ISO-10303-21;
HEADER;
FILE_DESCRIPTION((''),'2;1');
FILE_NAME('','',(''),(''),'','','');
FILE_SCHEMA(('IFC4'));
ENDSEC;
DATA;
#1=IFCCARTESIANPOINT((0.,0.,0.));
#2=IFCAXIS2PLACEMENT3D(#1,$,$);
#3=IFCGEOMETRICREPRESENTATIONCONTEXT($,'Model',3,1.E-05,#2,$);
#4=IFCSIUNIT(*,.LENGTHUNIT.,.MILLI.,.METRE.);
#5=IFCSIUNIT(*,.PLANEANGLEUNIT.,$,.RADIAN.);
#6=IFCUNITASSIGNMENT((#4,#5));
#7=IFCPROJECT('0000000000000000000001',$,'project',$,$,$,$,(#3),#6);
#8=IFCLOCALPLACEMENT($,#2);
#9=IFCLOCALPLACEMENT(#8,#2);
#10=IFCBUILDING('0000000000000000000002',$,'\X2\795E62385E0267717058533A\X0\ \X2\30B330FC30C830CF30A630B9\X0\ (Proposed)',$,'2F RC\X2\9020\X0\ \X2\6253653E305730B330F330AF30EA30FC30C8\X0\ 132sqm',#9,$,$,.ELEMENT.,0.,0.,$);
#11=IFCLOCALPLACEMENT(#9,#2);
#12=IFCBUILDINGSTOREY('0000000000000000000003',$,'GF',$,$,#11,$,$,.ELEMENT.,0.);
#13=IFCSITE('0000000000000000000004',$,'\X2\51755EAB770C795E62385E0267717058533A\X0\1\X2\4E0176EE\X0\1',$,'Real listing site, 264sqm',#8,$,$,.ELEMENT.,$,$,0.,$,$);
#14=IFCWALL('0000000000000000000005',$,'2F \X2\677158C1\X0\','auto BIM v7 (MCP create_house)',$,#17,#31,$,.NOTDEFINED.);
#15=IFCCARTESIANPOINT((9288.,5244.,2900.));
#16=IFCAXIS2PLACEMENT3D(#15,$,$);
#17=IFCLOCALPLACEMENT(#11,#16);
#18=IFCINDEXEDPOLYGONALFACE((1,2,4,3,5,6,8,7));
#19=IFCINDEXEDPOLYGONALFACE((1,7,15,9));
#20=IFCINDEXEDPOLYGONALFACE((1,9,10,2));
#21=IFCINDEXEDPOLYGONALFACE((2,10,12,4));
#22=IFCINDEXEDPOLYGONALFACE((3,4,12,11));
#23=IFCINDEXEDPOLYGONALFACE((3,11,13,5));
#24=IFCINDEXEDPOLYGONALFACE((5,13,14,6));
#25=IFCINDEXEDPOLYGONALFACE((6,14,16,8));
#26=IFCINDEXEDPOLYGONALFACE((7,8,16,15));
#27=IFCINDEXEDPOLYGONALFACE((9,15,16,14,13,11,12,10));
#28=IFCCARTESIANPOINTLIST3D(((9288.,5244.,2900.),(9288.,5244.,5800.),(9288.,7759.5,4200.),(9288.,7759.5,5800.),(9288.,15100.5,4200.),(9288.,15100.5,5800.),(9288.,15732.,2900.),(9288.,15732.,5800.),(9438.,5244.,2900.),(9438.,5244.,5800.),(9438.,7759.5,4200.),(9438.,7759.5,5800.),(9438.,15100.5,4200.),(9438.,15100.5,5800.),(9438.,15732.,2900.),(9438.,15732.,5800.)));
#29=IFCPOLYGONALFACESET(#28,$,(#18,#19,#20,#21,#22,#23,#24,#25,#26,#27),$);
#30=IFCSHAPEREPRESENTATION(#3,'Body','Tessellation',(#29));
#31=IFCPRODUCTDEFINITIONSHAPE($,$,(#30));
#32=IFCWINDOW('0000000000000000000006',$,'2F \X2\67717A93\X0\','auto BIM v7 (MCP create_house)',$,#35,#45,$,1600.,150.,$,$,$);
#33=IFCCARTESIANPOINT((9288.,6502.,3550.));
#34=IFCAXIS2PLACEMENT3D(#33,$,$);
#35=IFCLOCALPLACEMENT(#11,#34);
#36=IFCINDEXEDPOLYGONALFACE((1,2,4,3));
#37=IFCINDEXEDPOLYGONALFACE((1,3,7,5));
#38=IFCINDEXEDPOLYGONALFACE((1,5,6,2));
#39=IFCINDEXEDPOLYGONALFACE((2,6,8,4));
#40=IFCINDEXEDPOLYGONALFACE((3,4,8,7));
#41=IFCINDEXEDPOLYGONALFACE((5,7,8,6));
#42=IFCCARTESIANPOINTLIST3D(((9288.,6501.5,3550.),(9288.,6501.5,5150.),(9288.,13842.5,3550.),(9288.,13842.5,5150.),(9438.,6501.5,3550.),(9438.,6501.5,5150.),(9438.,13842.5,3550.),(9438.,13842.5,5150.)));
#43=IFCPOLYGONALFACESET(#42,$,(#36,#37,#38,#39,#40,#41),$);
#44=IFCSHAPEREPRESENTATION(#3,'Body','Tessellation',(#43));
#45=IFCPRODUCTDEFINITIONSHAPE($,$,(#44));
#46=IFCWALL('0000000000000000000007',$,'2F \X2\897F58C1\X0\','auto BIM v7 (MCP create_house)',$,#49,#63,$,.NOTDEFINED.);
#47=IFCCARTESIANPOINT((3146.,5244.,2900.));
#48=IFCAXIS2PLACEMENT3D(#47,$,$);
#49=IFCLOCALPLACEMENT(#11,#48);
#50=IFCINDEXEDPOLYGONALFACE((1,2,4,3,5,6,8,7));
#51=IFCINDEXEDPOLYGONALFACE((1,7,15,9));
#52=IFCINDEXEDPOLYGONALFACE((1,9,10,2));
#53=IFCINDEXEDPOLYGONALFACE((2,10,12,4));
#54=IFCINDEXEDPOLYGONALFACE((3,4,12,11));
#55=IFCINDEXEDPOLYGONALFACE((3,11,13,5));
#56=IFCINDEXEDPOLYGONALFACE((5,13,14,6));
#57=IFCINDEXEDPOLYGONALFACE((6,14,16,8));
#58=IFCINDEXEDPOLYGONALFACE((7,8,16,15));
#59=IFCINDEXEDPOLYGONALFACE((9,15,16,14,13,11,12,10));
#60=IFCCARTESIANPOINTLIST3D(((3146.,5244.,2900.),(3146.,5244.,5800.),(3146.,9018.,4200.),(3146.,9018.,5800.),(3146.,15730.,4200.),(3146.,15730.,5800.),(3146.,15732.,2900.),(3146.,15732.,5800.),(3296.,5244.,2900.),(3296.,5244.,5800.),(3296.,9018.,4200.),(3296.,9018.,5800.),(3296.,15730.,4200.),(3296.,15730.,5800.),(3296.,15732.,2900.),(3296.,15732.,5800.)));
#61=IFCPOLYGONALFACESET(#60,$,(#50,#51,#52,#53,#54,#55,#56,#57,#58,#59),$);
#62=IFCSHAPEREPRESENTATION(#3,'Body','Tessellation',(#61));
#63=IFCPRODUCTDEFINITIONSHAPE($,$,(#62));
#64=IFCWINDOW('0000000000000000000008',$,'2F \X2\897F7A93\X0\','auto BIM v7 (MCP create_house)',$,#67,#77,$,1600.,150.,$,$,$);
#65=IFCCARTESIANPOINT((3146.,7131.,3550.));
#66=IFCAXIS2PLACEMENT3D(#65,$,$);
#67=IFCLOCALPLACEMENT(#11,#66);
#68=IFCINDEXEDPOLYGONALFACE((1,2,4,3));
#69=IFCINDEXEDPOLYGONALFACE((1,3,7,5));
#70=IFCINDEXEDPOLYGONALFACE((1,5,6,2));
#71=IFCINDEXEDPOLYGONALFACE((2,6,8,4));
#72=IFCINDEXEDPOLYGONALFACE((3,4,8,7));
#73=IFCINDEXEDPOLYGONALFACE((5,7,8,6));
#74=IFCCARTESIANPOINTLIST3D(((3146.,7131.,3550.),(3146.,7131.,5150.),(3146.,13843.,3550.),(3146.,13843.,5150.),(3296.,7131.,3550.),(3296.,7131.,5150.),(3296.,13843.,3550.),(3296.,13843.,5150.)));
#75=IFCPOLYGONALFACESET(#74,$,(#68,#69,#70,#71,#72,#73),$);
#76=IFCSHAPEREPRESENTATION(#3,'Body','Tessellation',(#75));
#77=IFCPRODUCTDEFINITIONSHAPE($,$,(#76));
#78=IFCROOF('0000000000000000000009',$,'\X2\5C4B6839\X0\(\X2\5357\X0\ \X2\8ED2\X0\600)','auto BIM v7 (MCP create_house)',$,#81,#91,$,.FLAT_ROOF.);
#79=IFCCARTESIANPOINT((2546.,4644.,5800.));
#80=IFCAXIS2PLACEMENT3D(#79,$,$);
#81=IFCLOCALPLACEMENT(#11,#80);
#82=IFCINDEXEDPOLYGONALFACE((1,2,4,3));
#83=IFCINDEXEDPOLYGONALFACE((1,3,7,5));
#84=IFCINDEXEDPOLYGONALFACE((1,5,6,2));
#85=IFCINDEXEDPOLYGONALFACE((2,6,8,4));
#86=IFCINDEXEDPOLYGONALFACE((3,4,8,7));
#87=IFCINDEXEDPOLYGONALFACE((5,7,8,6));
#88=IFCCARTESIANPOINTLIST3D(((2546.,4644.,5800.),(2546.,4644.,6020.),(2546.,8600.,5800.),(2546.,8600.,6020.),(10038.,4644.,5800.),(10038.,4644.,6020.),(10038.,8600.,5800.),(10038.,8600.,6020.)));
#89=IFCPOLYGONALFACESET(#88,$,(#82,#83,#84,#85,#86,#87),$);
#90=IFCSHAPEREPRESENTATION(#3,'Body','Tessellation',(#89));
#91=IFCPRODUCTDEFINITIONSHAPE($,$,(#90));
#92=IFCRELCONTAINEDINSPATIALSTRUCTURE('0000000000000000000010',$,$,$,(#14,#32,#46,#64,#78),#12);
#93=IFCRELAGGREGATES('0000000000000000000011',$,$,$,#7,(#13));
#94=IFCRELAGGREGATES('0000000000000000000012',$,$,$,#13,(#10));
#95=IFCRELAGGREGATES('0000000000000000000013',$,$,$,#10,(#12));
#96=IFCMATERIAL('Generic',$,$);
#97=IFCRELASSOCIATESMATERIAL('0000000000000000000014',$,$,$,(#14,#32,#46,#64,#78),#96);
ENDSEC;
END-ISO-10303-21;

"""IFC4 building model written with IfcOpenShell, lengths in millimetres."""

from ifc_helpers import new_model, si_unit, frame, frame_2d, origin, place, context, project, spatial, rectangle, extrude, material, element, fill, save


model = new_model("IFC4")

# Units and contexts
model_context = context("Model", 3, precision=1e-05, world=origin())
ifc_project = project(units=[si_unit("LENGTHUNIT", "METRE", prefix="MILLI"), si_unit("PLANEANGLEUNIT", "RADIAN")], contexts=[model_context])

# Site, building, storey
site_placement = place(None, origin())
site = spatial("IfcSite", under=ifc_project, at=site_placement, Name="兵庫県神戸市東灘区1丁目1", ObjectType="Real listing site, 264sqm", CompositionType="ELEMENT", RefElevation=0.0)
building_placement = place(site_placement, origin())
building = spatial("IfcBuilding", under=site, at=building_placement, Name="神戸市東灘区 コートハウス (Proposed)", ObjectType="2F RC造 打放しコンクリート 132sqm", CompositionType="ELEMENT", ElevationOfRefHeight=0.0, ElevationOfTerrain=0.0)
storey_placement = place(building_placement, origin())
storey = spatial("IfcBuildingStorey", under=building, at=storey_placement, Name="GF", CompositionType="ELEMENT", Elevation=0.0)

# Shared definitions
ifc_material = material(Name="Generic")

# Walls, openings, windows
wall_1_placement = place(storey_placement, frame((9288.0, 5244.0, 2900.0)))
wall_1 = element("IfcWall", 1, at=wall_1_placement, inside=storey, material=ifc_material, Name="2F 東壁", Description="auto BIM v7 (MCP create_house)", PredefinedType="NOTDEFINED", context=model_context, shape_type="SweptSolid", body=[
    extrude(rectangle(XDim=150.0, YDim=10488.0, at=frame_2d((75.0, 5244.0))), frame((9288.0, 5244.0, 2900.0)), (0.0, 0.0, 1.0), 2900.0),
])
opening_1_placement = place(storey_placement, frame((9288.0, 6502.0, 3550.0)))
opening_1 = element("IfcOpeningElement", 2, at=opening_1_placement, cuts=wall_1, PredefinedType="NOTDEFINED", context=model_context, shape_type="SweptSolid", body=[
    extrude(rectangle(XDim=150.0, YDim=7341.0, at=frame_2d((75.0, 3670.0))), frame((9288.0, 6502.0, 3550.0)), (0.0, 0.0, 1.0), 1600.0),
])
window_1_placement = place(storey_placement, frame((9288.0, 6502.0, 3550.0)))
window_1 = element("IfcWindow", 3, at=window_1_placement, inside=storey, material=ifc_material, Name="2F 東窓", Description="auto BIM v7 (MCP create_house)", OverallHeight=1600.0, OverallWidth=150.0, context=model_context, shape_type="SweptSolid", body=[
    extrude(rectangle(XDim=150.0, YDim=7341.0, at=frame_2d((75.0, 3670.0))), frame((9288.0, 6502.0, 3550.0)), (0.0, 0.0, 1.0), 1600.0),
])
fill(opening_1, window_1)
wall_2_placement = place(storey_placement, frame((3146.0, 5244.0, 2900.0)))
wall_2 = element("IfcWall", 4, at=wall_2_placement, inside=storey, material=ifc_material, Name="2F 西壁", Description="auto BIM v7 (MCP create_house)", PredefinedType="NOTDEFINED", context=model_context, shape_type="SweptSolid", body=[
    extrude(rectangle(XDim=150.0, YDim=10488.0, at=frame_2d((75.0, 5244.0))), frame((3146.0, 5244.0, 2900.0)), (0.0, 0.0, 1.0), 2900.0),
])
opening_2_placement = place(storey_placement, frame((3146.0, 7131.0, 3550.0)))
opening_2 = element("IfcOpeningElement", 5, at=opening_2_placement, cuts=wall_2, PredefinedType="NOTDEFINED", context=model_context, shape_type="SweptSolid", body=[
    extrude(rectangle(XDim=150.0, YDim=6712.0, at=frame_2d((75.0, 3356.0))), frame((3146.0, 7131.0, 3550.0)), (0.0, 0.0, 1.0), 1600.0),
])
window_2_placement = place(storey_placement, frame((3146.0, 7131.0, 3550.0)))
window_2 = element("IfcWindow", 6, at=window_2_placement, inside=storey, material=ifc_material, Name="2F 西窓", Description="auto BIM v7 (MCP create_house)", OverallHeight=1600.0, OverallWidth=150.0, context=model_context, shape_type="SweptSolid", body=[
    extrude(rectangle(XDim=150.0, YDim=6712.0, at=frame_2d((75.0, 3356.0))), frame((3146.0, 7131.0, 3550.0)), (0.0, 0.0, 1.0), 1600.0),
])
fill(opening_2, window_2)

# Roof
roof_1_placement = place(storey_placement, frame((2546.0, 4644.0, 5800.0)))
element("IfcRoof", 7, at=roof_1_placement, inside=storey, material=ifc_material, Name="屋根(南 軒600)", Description="auto BIM v7 (MCP create_house)", PredefinedType="FLAT_ROOF", context=model_context, shape_type="SweptSolid", body=[
    extrude(rectangle(XDim=7492.0, YDim=3956.0, at=frame_2d((3746.0, 1978.0))), frame((2546.0, 4644.0, 5800.0)), (0.0, 0.0, 1.0), 220.0),
])

save(model, "model.ifc")
